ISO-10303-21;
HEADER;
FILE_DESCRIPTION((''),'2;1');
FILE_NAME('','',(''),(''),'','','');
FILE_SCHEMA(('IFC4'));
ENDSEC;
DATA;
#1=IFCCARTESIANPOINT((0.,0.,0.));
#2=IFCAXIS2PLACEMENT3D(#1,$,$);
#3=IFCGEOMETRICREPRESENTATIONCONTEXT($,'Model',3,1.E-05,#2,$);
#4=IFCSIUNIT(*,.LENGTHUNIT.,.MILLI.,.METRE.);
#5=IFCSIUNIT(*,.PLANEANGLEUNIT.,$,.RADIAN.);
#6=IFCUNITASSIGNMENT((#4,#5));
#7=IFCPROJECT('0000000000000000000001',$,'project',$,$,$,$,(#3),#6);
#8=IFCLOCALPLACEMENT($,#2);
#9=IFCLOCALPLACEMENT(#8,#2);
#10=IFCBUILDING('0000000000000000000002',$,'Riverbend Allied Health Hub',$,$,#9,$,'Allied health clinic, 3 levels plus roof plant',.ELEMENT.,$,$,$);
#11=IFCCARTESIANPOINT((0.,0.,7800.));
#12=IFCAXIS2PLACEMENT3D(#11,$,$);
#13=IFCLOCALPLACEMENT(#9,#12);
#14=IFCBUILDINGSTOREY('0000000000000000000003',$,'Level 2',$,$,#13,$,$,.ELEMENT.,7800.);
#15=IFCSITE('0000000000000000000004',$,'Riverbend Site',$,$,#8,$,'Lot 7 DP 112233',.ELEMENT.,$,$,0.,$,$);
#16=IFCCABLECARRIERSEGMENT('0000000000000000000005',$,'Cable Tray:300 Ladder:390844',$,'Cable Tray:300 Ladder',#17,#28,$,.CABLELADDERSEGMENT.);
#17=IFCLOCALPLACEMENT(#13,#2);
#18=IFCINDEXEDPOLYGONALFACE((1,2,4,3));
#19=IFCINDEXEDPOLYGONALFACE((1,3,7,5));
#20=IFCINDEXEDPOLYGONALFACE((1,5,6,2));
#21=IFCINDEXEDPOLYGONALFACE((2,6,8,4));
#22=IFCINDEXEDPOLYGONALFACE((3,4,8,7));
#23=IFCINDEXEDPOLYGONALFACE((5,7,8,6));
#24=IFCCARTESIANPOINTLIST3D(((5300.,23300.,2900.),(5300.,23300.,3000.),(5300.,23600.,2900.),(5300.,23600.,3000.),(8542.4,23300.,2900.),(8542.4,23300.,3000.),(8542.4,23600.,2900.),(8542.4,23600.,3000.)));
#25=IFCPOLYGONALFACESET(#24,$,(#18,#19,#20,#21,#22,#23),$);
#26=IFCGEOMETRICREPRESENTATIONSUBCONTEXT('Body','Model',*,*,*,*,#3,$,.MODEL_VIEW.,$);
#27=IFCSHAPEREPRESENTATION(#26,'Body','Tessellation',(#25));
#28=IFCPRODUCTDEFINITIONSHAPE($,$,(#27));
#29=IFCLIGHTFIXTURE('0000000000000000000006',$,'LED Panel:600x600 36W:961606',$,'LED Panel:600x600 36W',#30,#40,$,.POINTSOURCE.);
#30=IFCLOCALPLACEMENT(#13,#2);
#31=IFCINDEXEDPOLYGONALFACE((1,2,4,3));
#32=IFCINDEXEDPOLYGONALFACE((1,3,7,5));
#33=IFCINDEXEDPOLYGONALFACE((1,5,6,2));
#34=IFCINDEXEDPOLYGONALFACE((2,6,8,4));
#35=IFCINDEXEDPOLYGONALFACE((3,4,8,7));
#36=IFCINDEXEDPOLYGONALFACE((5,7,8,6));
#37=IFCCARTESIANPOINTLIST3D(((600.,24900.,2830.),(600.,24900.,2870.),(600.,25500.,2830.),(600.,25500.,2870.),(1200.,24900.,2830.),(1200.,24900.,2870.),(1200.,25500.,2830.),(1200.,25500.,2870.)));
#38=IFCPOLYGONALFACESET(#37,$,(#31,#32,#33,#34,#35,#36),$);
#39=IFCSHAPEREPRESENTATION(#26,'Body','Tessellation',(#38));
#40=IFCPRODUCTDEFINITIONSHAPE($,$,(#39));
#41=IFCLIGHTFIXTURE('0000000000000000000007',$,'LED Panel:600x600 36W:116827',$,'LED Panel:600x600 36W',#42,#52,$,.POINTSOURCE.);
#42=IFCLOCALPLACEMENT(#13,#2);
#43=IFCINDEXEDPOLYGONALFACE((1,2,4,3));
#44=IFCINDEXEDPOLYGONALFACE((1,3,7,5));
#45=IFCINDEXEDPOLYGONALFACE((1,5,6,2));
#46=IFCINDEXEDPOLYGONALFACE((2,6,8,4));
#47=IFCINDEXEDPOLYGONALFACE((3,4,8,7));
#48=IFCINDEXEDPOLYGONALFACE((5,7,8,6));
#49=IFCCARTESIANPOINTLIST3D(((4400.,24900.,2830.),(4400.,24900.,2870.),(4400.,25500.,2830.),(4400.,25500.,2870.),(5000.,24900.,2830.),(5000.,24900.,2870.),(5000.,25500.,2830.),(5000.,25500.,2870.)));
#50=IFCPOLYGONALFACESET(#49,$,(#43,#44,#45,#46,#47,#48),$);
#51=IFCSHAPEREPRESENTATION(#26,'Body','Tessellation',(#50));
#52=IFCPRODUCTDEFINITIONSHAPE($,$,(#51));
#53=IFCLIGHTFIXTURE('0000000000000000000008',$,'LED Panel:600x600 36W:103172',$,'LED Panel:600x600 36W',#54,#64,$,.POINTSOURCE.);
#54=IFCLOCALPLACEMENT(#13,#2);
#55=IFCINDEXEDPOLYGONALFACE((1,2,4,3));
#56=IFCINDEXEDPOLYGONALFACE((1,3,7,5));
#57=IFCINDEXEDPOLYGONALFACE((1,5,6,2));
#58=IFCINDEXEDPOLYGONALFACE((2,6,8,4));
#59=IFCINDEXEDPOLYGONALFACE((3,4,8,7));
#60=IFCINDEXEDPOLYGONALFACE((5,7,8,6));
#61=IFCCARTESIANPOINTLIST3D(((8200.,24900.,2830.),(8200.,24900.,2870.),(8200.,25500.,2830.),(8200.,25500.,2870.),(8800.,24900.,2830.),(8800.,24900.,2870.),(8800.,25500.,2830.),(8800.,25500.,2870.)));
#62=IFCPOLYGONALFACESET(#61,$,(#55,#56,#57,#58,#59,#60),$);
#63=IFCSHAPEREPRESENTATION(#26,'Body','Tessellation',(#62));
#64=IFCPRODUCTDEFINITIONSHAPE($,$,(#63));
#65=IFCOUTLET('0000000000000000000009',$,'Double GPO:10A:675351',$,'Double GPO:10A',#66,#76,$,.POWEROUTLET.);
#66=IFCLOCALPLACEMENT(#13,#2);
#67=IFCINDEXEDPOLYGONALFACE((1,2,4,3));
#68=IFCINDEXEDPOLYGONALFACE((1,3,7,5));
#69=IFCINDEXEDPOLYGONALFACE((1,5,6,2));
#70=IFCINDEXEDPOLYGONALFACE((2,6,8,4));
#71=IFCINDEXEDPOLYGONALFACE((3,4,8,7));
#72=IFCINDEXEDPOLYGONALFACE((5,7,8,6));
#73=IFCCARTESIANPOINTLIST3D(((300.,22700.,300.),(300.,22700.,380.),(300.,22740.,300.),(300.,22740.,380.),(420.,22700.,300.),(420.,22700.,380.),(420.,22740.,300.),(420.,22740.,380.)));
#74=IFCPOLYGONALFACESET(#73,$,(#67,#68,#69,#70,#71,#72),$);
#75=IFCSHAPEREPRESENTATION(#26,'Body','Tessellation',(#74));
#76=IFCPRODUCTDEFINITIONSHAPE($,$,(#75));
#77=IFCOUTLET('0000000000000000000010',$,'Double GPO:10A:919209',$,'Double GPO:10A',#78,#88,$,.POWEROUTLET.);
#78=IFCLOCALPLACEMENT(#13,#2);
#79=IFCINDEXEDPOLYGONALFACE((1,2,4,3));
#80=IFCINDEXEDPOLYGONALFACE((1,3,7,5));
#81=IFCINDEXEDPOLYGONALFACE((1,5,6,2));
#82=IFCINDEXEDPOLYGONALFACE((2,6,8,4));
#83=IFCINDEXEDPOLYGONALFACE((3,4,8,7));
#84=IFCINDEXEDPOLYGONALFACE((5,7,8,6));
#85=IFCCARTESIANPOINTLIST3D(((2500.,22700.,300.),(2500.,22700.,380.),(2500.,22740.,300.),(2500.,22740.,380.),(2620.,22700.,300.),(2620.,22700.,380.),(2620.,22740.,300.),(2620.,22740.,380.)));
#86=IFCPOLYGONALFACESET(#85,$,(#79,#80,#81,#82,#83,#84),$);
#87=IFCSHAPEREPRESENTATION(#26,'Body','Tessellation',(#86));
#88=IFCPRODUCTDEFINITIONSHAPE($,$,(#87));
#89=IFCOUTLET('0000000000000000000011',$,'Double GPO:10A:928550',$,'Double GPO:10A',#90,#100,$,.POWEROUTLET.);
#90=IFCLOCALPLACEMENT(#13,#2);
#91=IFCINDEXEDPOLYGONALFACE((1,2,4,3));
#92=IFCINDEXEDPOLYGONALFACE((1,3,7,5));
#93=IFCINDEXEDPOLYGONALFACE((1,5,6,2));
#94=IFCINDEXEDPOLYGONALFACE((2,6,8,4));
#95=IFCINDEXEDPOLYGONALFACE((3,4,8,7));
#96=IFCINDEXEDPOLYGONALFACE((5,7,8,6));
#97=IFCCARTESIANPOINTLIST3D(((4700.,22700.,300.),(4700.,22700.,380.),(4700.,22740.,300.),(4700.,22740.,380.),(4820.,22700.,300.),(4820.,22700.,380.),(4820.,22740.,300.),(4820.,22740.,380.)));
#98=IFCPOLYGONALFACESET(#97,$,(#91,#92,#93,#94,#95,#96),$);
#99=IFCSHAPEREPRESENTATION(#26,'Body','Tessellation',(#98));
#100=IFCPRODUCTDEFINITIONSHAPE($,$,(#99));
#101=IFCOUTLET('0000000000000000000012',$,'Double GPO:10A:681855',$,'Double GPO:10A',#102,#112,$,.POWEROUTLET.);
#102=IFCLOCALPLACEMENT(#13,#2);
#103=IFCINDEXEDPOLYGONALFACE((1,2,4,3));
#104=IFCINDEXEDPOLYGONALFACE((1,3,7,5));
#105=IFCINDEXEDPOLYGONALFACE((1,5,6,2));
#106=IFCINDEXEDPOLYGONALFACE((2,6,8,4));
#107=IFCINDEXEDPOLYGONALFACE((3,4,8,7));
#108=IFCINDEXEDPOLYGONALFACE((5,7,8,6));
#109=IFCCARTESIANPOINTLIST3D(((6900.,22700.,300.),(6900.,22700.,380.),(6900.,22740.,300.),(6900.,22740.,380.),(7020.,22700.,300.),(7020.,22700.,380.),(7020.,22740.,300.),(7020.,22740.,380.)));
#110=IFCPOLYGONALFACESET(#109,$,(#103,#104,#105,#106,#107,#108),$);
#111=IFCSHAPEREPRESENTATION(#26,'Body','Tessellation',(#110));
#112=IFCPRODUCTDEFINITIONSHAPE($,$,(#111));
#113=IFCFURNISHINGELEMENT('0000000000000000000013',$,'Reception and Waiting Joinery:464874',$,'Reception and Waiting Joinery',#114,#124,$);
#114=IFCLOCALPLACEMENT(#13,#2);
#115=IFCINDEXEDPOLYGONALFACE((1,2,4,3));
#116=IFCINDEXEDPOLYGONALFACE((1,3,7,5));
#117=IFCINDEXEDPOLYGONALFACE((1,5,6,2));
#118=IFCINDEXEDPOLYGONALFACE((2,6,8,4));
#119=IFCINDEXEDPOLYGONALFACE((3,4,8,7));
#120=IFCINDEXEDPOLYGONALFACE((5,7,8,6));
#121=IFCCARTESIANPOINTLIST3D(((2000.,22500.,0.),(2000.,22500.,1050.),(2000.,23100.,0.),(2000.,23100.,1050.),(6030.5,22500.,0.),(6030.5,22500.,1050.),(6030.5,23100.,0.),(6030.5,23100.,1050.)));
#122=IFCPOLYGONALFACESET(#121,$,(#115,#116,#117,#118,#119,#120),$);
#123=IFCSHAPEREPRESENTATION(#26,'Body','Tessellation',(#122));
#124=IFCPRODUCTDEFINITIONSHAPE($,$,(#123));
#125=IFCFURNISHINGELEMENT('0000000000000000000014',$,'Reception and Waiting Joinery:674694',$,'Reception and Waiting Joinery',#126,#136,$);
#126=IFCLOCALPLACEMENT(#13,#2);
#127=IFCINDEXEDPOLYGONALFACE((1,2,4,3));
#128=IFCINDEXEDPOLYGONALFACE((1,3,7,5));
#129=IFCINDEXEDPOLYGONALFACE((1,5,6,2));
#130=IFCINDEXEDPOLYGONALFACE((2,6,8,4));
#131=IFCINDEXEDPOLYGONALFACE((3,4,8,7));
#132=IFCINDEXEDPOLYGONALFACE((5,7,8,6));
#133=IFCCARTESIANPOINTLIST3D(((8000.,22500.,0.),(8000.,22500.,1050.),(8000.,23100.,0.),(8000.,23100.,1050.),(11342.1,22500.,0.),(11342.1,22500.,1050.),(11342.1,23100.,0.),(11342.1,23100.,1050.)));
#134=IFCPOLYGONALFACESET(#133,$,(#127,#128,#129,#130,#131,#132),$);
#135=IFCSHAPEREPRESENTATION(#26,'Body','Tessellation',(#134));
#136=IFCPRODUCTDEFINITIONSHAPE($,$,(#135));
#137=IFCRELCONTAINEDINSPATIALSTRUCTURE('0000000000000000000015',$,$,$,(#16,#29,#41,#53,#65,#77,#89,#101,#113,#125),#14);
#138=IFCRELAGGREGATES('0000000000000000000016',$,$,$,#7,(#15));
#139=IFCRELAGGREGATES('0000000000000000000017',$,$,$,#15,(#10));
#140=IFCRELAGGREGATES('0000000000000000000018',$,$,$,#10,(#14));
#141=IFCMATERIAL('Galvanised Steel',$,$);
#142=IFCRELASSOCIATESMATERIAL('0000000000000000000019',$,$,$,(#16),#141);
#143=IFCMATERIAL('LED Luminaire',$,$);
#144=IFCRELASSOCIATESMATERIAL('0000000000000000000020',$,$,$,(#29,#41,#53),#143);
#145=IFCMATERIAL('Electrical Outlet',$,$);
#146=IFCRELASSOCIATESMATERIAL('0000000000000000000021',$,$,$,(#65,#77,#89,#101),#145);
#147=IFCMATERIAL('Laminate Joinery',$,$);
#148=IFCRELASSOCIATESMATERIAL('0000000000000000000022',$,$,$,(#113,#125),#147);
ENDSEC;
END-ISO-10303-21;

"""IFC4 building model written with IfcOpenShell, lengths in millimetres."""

from ifc_helpers import new_model, si_unit, frame, frame_2d, origin, place, context, subcontext, project, spatial, rectangle, extrude, material, element, save


model = new_model("IFC4")

# Units and contexts
model_context = context("Model", 3, precision=1e-05, world=origin())
body_context = subcontext(model_context, "Body", "Model", "MODEL_VIEW")
ifc_project = project(units=[si_unit("LENGTHUNIT", "METRE", prefix="MILLI"), si_unit("PLANEANGLEUNIT", "RADIAN")], contexts=[model_context])

# Site, building, storey
site_placement = place(None, origin())
site = spatial("IfcSite", under=ifc_project, at=site_placement, Name="Riverbend Site", LongName="Lot 7 DP 112233", CompositionType="ELEMENT", RefElevation=0.0)
building_placement = place(site_placement, origin())
building = spatial("IfcBuilding", under=site, at=building_placement, Name="Riverbend Allied Health Hub", LongName="Allied health clinic, 3 levels plus roof plant", CompositionType="ELEMENT")
storey_placement = place(building_placement, frame((0.0, 0.0, 7800.0)))
storey = spatial("IfcBuildingStorey", under=building, at=storey_placement, Name="Level 2", CompositionType="ELEMENT", Elevation=7800.0)

# Shared definitions
ifc_material_1 = material(Name="Galvanised Steel")

# Cable carrier segment
cable_carrier_segment_1_placement = place(storey_placement, frame((5300.0, 23300.0, 2900.0)))
element("IfcCableCarrierSegment", 1, at=cable_carrier_segment_1_placement, inside=storey, material=ifc_material_1, Name="Cable Tray:300 Ladder:390844", ObjectType="Cable Tray:300 Ladder", PredefinedType="CABLELADDERSEGMENT", context=body_context, shape_type="SweptSolid", body=[
    extrude(rectangle(XDim=3242.4, YDim=300.0, at=frame_2d((1621.2, 150.0))), origin(), (0.0, 0.0, 1.0), 100.0),
])

# Light fixtures
ifc_material_2 = material(Name="LED Luminaire")
for number, where, name in (
    (2, (600.0, 24900.0, 2830.0), "LED Panel:600x600 36W:961606"),
    (3, (4400.0, 24900.0, 2830.0), "LED Panel:600x600 36W:116827"),
    (4, (8200.0, 24900.0, 2830.0), "LED Panel:600x600 36W:103172"),
):
    element("IfcLightFixture", number, at=place(storey_placement, frame(where)), inside=storey, material=ifc_material_2, Name=name, ObjectType="LED Panel:600x600 36W", PredefinedType="POINTSOURCE", context=body_context, shape_type="SweptSolid", body=[
        extrude(rectangle(XDim=600.0, YDim=600.0, at=frame_2d((300.0, 300.0))), origin(), (0.0, 0.0, 1.0), 40.0),
    ])

# Outlets
ifc_material_3 = material(Name="Electrical Outlet")
for number, where, name in (
    (5, (300.0, 22700.0, 300.0), "Double GPO:10A:675351"),
    (6, (2500.0, 22700.0, 300.0), "Double GPO:10A:919209"),
    (7, (4700.0, 22700.0, 300.0), "Double GPO:10A:928550"),
    (8, (6900.0, 22700.0, 300.0), "Double GPO:10A:681855"),
):
    element("IfcOutlet", number, at=place(storey_placement, frame(where)), inside=storey, material=ifc_material_3, Name=name, ObjectType="Double GPO:10A", PredefinedType="POWEROUTLET", context=body_context, shape_type="SweptSolid", body=[
        extrude(rectangle(XDim=120.0, YDim=40.0, at=frame_2d((60.0, 20.0))), origin(), (0.0, 0.0, 1.0), 80.0),
    ])

# Furnishing elements
ifc_material_4 = material(Name="Laminate Joinery")
furnishing_1_placement = place(storey_placement, frame((2000.0, 22500.0, 0.0)))
element("IfcFurnishingElement", 9, at=furnishing_1_placement, inside=storey, material=ifc_material_4, Name="Reception and Waiting Joinery:464874", ObjectType="Reception and Waiting Joinery", context=body_context, shape_type="SweptSolid", body=[
    extrude(rectangle(XDim=4030.5, YDim=600.0, at=frame_2d((2015.3, 300.0))), origin(), (0.0, 0.0, 1.0), 1050.0),
])
furnishing_2_placement = place(storey_placement, frame((8000.0, 22500.0, 0.0)))
element("IfcFurnishingElement", 10, at=furnishing_2_placement, inside=storey, material=ifc_material_4, Name="Reception and Waiting Joinery:674694", ObjectType="Reception and Waiting Joinery", context=body_context, shape_type="SweptSolid", body=[
    extrude(rectangle(XDim=3342.1, YDim=600.0, at=frame_2d((1671.1, 300.0))), origin(), (0.0, 0.0, 1.0), 1050.0),
])

save(model, "model.ifc")
